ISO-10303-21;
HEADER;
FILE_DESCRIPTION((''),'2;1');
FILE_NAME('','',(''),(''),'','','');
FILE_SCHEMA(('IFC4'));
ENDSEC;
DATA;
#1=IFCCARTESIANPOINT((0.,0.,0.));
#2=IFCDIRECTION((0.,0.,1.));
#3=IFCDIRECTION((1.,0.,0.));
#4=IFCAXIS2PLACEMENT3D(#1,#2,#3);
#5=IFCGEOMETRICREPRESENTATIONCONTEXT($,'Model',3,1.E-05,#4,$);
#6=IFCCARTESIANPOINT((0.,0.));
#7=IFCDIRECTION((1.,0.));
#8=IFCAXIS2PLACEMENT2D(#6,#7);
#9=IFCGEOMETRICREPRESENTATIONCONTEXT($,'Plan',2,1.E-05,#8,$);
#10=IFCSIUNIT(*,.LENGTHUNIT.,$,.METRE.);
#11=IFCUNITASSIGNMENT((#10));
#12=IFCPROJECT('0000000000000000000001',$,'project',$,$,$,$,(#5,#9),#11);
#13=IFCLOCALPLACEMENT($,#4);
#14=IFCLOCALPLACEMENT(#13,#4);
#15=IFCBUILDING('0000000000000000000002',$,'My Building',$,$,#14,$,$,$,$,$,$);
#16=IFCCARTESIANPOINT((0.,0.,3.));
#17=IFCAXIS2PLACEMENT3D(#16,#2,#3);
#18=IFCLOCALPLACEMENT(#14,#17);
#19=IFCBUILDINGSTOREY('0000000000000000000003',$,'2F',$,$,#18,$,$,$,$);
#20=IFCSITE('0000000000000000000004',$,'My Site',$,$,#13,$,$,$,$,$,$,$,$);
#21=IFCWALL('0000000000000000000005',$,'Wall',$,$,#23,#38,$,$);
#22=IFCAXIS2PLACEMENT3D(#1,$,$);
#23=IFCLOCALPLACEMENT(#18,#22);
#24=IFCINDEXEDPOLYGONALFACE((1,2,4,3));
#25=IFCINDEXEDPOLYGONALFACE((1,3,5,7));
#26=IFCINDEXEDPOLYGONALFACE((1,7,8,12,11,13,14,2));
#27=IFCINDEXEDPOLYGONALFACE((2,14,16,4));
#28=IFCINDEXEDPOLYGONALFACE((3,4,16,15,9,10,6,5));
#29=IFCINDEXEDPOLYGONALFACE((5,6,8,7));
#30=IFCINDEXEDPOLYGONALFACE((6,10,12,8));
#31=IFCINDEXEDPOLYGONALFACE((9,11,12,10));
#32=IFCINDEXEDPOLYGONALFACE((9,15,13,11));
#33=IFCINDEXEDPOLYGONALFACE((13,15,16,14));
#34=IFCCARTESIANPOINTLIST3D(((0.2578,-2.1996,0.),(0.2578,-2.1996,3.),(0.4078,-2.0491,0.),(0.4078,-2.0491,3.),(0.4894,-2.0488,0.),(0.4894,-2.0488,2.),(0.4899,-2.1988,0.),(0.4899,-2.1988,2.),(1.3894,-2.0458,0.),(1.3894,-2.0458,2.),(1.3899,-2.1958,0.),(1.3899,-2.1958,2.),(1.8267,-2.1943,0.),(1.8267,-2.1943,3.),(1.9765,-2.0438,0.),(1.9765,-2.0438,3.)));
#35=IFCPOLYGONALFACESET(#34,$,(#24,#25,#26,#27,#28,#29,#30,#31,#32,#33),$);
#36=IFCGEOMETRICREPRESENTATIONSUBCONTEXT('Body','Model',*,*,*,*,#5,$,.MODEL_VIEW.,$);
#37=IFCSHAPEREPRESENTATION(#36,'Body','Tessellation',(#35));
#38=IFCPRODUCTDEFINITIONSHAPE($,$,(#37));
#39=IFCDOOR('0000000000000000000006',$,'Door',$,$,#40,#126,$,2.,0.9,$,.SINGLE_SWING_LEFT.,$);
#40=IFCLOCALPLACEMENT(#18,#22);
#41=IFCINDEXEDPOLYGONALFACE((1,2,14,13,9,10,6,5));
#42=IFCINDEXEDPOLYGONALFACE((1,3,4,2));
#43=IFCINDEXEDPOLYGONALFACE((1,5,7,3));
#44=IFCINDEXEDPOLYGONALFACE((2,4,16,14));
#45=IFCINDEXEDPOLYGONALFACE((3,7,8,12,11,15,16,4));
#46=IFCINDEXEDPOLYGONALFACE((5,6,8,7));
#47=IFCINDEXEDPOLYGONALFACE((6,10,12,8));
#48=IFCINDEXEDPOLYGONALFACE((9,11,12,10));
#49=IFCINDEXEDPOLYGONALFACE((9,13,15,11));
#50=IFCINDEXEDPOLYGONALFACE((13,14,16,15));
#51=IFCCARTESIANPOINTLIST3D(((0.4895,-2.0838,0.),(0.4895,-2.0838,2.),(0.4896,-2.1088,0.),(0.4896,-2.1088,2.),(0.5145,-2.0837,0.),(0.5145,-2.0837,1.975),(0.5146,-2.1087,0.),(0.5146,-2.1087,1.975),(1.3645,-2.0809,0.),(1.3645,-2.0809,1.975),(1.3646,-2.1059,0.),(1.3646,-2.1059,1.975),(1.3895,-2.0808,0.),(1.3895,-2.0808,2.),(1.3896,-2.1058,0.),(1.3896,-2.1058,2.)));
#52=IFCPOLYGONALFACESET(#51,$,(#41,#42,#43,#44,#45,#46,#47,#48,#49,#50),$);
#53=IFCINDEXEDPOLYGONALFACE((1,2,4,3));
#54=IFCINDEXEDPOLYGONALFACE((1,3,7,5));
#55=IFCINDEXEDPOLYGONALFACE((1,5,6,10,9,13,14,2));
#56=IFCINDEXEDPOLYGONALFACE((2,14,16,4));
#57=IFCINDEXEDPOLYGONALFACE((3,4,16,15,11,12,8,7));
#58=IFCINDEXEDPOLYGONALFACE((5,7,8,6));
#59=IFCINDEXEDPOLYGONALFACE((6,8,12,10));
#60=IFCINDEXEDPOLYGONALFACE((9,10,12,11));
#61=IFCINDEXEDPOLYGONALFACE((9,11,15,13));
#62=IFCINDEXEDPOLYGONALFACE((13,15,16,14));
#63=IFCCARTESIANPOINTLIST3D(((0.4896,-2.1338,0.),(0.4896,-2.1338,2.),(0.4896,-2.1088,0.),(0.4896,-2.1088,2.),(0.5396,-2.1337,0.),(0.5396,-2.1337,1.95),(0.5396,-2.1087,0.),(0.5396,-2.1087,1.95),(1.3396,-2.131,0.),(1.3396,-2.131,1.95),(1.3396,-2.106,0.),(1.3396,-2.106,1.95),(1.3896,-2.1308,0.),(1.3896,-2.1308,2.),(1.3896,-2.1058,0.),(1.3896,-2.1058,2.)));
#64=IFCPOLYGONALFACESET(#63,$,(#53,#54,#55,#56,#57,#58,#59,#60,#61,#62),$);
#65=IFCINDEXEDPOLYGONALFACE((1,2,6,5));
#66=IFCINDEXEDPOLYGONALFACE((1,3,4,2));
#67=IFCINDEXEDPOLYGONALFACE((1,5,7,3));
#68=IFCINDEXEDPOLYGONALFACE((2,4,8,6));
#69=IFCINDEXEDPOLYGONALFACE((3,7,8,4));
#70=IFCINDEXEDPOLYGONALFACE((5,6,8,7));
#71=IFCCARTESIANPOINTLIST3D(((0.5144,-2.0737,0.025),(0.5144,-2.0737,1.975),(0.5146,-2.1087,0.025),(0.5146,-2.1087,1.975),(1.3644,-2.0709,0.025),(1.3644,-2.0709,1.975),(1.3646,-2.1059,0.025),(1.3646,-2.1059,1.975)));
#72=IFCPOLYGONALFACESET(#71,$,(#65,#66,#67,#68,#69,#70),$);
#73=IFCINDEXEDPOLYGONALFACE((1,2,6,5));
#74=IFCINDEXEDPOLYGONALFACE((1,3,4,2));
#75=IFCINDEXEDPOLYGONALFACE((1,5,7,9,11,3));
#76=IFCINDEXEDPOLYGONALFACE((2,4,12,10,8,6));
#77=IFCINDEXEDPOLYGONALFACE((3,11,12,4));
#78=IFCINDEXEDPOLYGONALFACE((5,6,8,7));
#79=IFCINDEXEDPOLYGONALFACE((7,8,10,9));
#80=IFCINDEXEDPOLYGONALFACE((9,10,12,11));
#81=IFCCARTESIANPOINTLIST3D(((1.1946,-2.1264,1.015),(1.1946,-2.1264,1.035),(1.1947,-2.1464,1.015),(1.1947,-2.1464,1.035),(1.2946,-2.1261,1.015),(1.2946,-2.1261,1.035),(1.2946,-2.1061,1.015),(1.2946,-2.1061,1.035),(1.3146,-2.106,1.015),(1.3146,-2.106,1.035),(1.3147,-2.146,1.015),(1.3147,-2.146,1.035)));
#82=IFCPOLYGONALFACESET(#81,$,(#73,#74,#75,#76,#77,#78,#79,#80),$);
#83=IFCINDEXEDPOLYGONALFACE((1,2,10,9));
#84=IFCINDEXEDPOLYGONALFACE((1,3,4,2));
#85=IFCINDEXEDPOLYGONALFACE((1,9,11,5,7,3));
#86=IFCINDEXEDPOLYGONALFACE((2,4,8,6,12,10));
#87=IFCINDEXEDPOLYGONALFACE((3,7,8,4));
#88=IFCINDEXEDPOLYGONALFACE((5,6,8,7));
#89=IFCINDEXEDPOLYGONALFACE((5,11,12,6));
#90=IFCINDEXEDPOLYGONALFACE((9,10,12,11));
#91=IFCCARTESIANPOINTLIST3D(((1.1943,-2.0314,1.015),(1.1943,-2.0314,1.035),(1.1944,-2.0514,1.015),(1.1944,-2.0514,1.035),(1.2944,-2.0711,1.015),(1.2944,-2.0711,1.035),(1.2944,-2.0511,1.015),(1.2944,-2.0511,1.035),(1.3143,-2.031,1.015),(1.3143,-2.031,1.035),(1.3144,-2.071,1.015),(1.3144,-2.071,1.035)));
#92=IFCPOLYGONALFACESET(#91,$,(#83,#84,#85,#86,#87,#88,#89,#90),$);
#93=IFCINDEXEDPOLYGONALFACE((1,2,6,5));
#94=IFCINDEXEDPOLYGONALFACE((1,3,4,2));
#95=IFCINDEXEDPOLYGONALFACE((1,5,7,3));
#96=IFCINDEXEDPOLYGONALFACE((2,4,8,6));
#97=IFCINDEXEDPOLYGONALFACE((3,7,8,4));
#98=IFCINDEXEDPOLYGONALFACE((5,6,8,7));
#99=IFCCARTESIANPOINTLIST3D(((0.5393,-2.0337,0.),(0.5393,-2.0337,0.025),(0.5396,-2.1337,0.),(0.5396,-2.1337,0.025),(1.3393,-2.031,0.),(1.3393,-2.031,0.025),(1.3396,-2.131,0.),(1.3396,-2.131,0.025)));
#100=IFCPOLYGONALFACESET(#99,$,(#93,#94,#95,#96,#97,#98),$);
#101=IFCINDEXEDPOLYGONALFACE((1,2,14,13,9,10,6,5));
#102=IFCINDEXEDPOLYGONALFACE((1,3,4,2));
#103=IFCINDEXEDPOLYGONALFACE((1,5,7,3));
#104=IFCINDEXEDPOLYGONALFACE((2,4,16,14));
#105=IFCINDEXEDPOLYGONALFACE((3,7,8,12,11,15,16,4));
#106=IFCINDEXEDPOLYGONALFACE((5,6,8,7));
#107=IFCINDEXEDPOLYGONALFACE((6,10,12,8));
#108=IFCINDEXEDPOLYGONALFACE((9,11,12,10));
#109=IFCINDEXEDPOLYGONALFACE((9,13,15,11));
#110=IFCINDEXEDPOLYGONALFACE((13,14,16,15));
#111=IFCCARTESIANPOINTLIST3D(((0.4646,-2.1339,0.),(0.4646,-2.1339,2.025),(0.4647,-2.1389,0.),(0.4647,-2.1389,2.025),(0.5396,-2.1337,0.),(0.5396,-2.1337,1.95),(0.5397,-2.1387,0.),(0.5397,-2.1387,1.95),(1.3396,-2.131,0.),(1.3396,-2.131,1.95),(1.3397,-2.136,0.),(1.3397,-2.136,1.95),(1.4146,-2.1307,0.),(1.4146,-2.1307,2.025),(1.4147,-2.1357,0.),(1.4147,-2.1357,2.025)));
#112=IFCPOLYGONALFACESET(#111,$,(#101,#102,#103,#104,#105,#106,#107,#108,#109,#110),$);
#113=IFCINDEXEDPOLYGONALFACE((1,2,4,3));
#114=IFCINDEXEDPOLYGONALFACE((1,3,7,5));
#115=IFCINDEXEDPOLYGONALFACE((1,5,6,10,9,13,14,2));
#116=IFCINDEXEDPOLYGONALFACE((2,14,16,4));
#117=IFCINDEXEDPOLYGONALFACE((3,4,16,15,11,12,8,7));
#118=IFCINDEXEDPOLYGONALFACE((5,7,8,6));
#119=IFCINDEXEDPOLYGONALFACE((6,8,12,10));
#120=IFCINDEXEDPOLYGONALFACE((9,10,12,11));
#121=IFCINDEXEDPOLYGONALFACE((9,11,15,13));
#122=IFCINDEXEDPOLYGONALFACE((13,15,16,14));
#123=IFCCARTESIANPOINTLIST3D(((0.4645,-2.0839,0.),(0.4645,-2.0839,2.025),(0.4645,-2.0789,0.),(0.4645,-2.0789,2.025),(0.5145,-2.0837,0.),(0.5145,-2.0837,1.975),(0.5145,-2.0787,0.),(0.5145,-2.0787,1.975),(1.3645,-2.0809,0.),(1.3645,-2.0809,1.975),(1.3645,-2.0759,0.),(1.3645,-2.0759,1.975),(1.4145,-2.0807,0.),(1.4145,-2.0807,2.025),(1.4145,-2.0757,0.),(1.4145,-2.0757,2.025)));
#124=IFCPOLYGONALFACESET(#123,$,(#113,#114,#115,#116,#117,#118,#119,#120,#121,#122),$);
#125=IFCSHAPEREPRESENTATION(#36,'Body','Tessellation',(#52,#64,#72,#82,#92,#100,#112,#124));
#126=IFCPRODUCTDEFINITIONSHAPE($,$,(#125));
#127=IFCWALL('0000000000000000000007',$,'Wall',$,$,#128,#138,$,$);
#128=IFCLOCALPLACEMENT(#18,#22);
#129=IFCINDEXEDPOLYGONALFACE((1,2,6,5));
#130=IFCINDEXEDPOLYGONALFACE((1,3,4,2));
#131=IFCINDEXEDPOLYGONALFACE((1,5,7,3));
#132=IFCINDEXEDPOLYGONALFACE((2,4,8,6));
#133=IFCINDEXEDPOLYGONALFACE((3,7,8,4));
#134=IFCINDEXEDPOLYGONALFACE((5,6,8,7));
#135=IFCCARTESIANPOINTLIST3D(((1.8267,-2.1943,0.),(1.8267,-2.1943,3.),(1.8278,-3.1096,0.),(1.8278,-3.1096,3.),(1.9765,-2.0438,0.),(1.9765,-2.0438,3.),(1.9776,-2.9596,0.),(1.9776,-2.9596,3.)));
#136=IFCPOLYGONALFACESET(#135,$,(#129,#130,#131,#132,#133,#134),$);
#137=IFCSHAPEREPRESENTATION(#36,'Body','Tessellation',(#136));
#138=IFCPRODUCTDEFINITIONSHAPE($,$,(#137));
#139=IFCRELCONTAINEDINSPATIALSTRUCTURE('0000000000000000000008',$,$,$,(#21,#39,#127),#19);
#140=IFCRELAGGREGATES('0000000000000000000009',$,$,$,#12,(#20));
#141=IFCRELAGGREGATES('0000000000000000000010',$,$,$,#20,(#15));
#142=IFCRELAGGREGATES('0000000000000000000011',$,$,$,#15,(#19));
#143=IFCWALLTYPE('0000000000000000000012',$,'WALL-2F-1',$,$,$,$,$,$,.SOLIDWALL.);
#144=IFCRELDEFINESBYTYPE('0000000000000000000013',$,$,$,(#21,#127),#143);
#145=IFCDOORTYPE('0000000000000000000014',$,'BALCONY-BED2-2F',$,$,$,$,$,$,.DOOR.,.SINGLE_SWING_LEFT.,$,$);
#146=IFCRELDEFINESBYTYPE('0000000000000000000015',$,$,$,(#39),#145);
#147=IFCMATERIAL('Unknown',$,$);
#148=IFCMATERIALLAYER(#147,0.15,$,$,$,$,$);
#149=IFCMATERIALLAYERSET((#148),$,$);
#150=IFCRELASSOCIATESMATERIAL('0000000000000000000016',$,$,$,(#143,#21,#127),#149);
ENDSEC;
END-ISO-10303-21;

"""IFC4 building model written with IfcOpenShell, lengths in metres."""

from ifc_helpers import new_model, entity, si_unit, frame, origin_with_axes, origin_2d_with_axis, place, context, subcontext, project, spatial, line, indexed_curve, outline, extrude, shape, source, transform, mapped, material, layer, layer_set, layer_usage, type_object, type_shapes, element, fill, save


model = new_model("IFC4")

# Units and contexts
model_context = context("Model", 3, precision=1e-05, world=origin_with_axes())
plan_context = context("Plan", 2, precision=1e-05, world=origin_2d_with_axis())
body_context_1 = subcontext(model_context, "Body", "Model", "MODEL_VIEW")
body_context_2 = subcontext(plan_context, "Body", "Plan", "PLAN_VIEW")
ifc_project = project(units=[si_unit("LENGTHUNIT", "METRE")], contexts=[model_context, plan_context])

# Site, building, storey
site_placement = place(None, origin_with_axes())
site = spatial("IfcSite", under=ifc_project, at=site_placement, Name="My Site")
building_placement = place(site_placement, origin_with_axes())
building = spatial("IfcBuilding", under=site, at=building_placement, Name="My Building")
storey_placement = place(building_placement, frame((0.0, 0.0, 3.0), z_axis=(0.0, 0.0, 1.0), x_axis=(1.0, 0.0, 0.0)))
storey = spatial("IfcBuildingStorey", under=building, at=storey_placement, Name="2F")

# Shared definitions
ifc_material = material(Name="Unknown")

# Shared definitions
ifc_layer_1 = layer(ifc_material, 0.15)
ifc_layer_set_1 = layer_set([ifc_layer_1])
wall_type_1 = type_object("IfcWallType", Name="WALL-2F-1", PredefinedType="SOLIDWALL", material=ifc_layer_set_1)

# Wall, opening, door
ifc_layer_usage_1 = layer_usage(ifc_layer_set_1, "AXIS2", "POSITIVE", 0.0)
wall_1_placement = place(storey_placement, frame((0.2578, -2.1996, 0.0), z_axis=(0.0, 0.0, 1.0), x_axis=(0.999994, 0.003371, 0.0)))
wall_1 = element("IfcWall", 1, at=wall_1_placement, inside=storey, type_object=wall_type_1, material=ifc_layer_usage_1, Name="Wall", context=body_context_1, shape_type="SweptSolid", body=[
    extrude(outline(indexed_curve([(0.0, 0.0), (0.1505, 0.15), (1.7192, 0.15), (1.5689, 0.0)], segments=[line(1, 2, 3, 4, 1)])), origin_with_axes(), (0.0, 0.0, 1.0), 3.0),
])
shared_shape_1 = source(origin_with_axes(), body_context_1, "Body", "SweptSolid", [
    extrude(outline(indexed_curve([(0.0, 0.0), (0.9, 0.0), (0.9, 2.0), (0.0, 2.0)], segments=[line(1, 2, 3, 4, 1)])), frame((0.0, -0.6, 0.0), z_axis=(0.0, -1.0, 0.0), x_axis=(1.0, 0.0, 0.0)), (0.0, 0.0, -1.0), 1.2),
])
opening_1_placement = place(wall_1_placement, frame((0.2321, 0.065, 0.0), z_axis=(0.0, 0.0, 1.0), x_axis=(1.0, 0.0, 0.0)))
opening_1 = element("IfcOpeningElement", 2, at=opening_1_placement, cuts=wall_1, PredefinedType="OPENING", context=body_context_1, shape_type="MappedRepresentation", body=[
    mapped(shared_shape_1, transform((0.0, 0.0, 0.0), x_axis=(1.0, 0.0, 0.0), y_axis=(0.0, 1.0, 0.0), z_axis=(0.0, 0.0, 1.0), scale=1.0)),
])
door_type_1 = type_object("IfcDoorType", Name="BALCONY-BED2-2F", OperationType="SINGLE_SWING_LEFT", PredefinedType="DOOR")
shared_shape_2 = source(origin_with_axes(), body_context_1, "Body", "SweptSolid", [
    extrude(outline(indexed_curve([(0.0, 0.0), (0.0, 2.0), (0.9, 2.0), (0.9, 0.0), (0.875, 0.0), (0.875, 1.975), (0.025, 1.975), (0.025, 0.0)], segments=[line(1, 2, 3, 4, 5, 6, 7, 8, 1)])), frame((0.0, 0.025, 0.0), z_axis=(0.0, -1.0, 0.0), x_axis=(1.0, 0.0, 0.0)), (0.0, 0.0, -1.0), 0.025),
    extrude(outline(indexed_curve([(0.0, 0.0), (0.0, 2.0), (0.9, 2.0), (0.9, 0.0), (0.85, 0.0), (0.85, 1.95), (0.05, 1.95), (0.05, 0.0)], segments=[line(1, 2, 3, 4, 5, 6, 7, 8, 1)])), frame((0.0, 0.0, 0.0), z_axis=(0.0, -1.0, 0.0), x_axis=(1.0, 0.0, 0.0)), (0.0, 0.0, -1.0), 0.025),
    extrude(outline(indexed_curve([(0.0, 0.0), (0.85, 0.0), (0.85, 0.035), (0.0, 0.035)], segments=[line(1, 2, 3, 4, 1)])), frame((0.025, 0.025, 0.025), z_axis=(0.0, 0.0, 1.0), x_axis=(1.0, 0.0, 0.0)), (0.0, 0.0, 1.0), 1.95),
    extrude(outline(indexed_curve([(0.0, 0.0), (0.0, -0.04), (-0.12, -0.04), (-0.12, -0.02), (-0.02, -0.02), (-0.02, 0.0)], segments=[line(1, 2, 3, 4, 5, 6, 1)])), frame((0.825, 0.025, 1.015), z_axis=(0.0, 0.0, 1.0), x_axis=(1.0, 0.0, 0.0)), (0.0, 0.0, 1.0), 0.02),
    extrude(outline(indexed_curve([(0.0, 0.0), (0.0, 0.04), (-0.12, 0.04), (-0.12, 0.02), (-0.02, 0.02), (-0.02, 0.0)], segments=[line(1, 2, 3, 4, 5, 6, 1)])), frame((0.825, 0.06, 1.015), z_axis=(0.0, 0.0, 1.0), x_axis=(1.0, 0.0, 0.0)), (0.0, 0.0, 1.0), 0.02),
    extrude(outline(indexed_curve([(0.0, 0.0), (0.8, 0.0), (0.8, 0.1), (0.0, 0.1)], segments=[line(1, 2, 3, 4, 1)])), frame((0.05, 0.0, 0.0), z_axis=(0.0, 0.0, 1.0), x_axis=(1.0, 0.0, 0.0)), (0.0, 0.0, 1.0), 0.025),
    extrude(outline(indexed_curve([(0.0, 0.0), (0.0, 2.025), (0.95, 2.025), (0.95, 0.0), (0.875, 0.0), (0.875, 1.95), (0.075, 1.95), (0.075, 0.0)], segments=[line(1, 2, 3, 4, 5, 6, 7, 8, 1)])), frame((-0.025, -0.005, 0.0), z_axis=(0.0, -1.0, 0.0), x_axis=(1.0, 0.0, 0.0)), (0.0, 0.0, -1.0), 0.005),
    extrude(outline(indexed_curve([(0.0, 0.0), (0.0, 2.025), (0.95, 2.025), (0.95, 0.0), (0.9, 0.0), (0.9, 1.975), (0.05, 1.975), (0.05, 0.0)], segments=[line(1, 2, 3, 4, 5, 6, 7, 8, 1)])), frame((-0.025, 0.05, 0.0), z_axis=(0.0, -1.0, 0.0), x_axis=(1.0, 0.0, 0.0)), (0.0, 0.0, -1.0), 0.005),
])
shared_shape_3 = source(origin_with_axes(), body_context_2, "Body", "Curve2D", [
    entity("IfcIndexedPolyCurve", entity("IfcCartesianPointList2D", [[0.0, 0.0], [0.0, 0.05], [0.025, 0.05], [0.025, 0.025], [0.05, 0.025], [0.05, 0.0]]), [entity("IfcLineIndex", [1, 2, 3, 4, 5, 6, 1])]),
    entity("IfcIndexedPolyCurve", entity("IfcCartesianPointList2D", [[0.9, 0.0], [0.9, 0.05], [0.875, 0.05], [0.875, 0.025], [0.85, 0.025], [0.85, 0.0]]), [entity("IfcLineIndex", [1, 2, 3, 4, 5, 6, 1])]),
    entity("IfcTrimmedCurve", entity("IfcEllipse", entity("IfcAxis2Placement2D", entity("IfcCartesianPoint", [0.06, 0.05]), entity("IfcDirection", [1.0, 0.0])), 0.815, 0.85), [entity("IfcCartesianPoint", [0.875, 0.05])], [entity("IfcCartesianPoint", [0.06, 0.9])], True, "CARTESIAN"),
    entity("IfcIndexedPolyCurve", entity("IfcCartesianPointList2D", [[0.025, 0.05], [0.06, 0.05], [0.06, 0.9], [0.025, 0.9]]), [entity("IfcLineIndex", [1, 2, 3, 4, 1])]),
])
type_shapes(door_type_1, [shared_shape_2, shared_shape_3])
door_1_placement = place(opening_1_placement, frame((0.0, 0.0, 0.0), z_axis=(0.0, 0.0, 1.0), x_axis=(1.0, 0.0, 0.0)))
door_1 = element("IfcDoor", 3, at=door_1_placement, inside=storey, type_object=door_type_1, Name="Door", OperationType="SINGLE_SWING_LEFT", OverallHeight=2.0, OverallWidth=0.9, shapes=[
    shape(body_context_1, "Body", "MappedRepresentation", [mapped(shared_shape_2, transform((0.0, 0.0, 0.0), x_axis=(1.0, 0.0, 0.0), y_axis=(0.0, 1.0, 0.0), z_axis=(0.0, 0.0, 1.0), scale=1.0))]),
    shape(body_context_2, "Body", "MappedRepresentation", [mapped(shared_shape_3, transform((0.0, 0.0, 0.0), x_axis=(1.0, 0.0, 0.0), y_axis=(0.0, 1.0, 0.0), z_axis=(0.0, 0.0, 1.0), scale=1.0))]),
])
fill(opening_1, door_1)

# Wall
ifc_layer_usage_2 = layer_usage(ifc_layer_set_1, "AXIS2", "POSITIVE", 0.0)
wall_2_placement = place(storey_placement, frame((1.8267, -2.1943, 0.0), z_axis=(0.0, 0.0, 1.0), x_axis=(0.001208, -0.999999, 0.0)))
element("IfcWall", 4, at=wall_2_placement, inside=storey, type_object=wall_type_1, material=ifc_layer_usage_2, Name="Wall", context=body_context_1, shape_type="SweptSolid", body=[
    extrude(outline(indexed_curve([(0.0, 0.0), (-0.1503, 0.15), (0.7655, 0.15), (0.9153, 0.0)], segments=[line(1, 2, 3, 4, 1)])), origin_with_axes(), (0.0, 0.0, 1.0), 3.0),
])

save(model, "model.ifc")
